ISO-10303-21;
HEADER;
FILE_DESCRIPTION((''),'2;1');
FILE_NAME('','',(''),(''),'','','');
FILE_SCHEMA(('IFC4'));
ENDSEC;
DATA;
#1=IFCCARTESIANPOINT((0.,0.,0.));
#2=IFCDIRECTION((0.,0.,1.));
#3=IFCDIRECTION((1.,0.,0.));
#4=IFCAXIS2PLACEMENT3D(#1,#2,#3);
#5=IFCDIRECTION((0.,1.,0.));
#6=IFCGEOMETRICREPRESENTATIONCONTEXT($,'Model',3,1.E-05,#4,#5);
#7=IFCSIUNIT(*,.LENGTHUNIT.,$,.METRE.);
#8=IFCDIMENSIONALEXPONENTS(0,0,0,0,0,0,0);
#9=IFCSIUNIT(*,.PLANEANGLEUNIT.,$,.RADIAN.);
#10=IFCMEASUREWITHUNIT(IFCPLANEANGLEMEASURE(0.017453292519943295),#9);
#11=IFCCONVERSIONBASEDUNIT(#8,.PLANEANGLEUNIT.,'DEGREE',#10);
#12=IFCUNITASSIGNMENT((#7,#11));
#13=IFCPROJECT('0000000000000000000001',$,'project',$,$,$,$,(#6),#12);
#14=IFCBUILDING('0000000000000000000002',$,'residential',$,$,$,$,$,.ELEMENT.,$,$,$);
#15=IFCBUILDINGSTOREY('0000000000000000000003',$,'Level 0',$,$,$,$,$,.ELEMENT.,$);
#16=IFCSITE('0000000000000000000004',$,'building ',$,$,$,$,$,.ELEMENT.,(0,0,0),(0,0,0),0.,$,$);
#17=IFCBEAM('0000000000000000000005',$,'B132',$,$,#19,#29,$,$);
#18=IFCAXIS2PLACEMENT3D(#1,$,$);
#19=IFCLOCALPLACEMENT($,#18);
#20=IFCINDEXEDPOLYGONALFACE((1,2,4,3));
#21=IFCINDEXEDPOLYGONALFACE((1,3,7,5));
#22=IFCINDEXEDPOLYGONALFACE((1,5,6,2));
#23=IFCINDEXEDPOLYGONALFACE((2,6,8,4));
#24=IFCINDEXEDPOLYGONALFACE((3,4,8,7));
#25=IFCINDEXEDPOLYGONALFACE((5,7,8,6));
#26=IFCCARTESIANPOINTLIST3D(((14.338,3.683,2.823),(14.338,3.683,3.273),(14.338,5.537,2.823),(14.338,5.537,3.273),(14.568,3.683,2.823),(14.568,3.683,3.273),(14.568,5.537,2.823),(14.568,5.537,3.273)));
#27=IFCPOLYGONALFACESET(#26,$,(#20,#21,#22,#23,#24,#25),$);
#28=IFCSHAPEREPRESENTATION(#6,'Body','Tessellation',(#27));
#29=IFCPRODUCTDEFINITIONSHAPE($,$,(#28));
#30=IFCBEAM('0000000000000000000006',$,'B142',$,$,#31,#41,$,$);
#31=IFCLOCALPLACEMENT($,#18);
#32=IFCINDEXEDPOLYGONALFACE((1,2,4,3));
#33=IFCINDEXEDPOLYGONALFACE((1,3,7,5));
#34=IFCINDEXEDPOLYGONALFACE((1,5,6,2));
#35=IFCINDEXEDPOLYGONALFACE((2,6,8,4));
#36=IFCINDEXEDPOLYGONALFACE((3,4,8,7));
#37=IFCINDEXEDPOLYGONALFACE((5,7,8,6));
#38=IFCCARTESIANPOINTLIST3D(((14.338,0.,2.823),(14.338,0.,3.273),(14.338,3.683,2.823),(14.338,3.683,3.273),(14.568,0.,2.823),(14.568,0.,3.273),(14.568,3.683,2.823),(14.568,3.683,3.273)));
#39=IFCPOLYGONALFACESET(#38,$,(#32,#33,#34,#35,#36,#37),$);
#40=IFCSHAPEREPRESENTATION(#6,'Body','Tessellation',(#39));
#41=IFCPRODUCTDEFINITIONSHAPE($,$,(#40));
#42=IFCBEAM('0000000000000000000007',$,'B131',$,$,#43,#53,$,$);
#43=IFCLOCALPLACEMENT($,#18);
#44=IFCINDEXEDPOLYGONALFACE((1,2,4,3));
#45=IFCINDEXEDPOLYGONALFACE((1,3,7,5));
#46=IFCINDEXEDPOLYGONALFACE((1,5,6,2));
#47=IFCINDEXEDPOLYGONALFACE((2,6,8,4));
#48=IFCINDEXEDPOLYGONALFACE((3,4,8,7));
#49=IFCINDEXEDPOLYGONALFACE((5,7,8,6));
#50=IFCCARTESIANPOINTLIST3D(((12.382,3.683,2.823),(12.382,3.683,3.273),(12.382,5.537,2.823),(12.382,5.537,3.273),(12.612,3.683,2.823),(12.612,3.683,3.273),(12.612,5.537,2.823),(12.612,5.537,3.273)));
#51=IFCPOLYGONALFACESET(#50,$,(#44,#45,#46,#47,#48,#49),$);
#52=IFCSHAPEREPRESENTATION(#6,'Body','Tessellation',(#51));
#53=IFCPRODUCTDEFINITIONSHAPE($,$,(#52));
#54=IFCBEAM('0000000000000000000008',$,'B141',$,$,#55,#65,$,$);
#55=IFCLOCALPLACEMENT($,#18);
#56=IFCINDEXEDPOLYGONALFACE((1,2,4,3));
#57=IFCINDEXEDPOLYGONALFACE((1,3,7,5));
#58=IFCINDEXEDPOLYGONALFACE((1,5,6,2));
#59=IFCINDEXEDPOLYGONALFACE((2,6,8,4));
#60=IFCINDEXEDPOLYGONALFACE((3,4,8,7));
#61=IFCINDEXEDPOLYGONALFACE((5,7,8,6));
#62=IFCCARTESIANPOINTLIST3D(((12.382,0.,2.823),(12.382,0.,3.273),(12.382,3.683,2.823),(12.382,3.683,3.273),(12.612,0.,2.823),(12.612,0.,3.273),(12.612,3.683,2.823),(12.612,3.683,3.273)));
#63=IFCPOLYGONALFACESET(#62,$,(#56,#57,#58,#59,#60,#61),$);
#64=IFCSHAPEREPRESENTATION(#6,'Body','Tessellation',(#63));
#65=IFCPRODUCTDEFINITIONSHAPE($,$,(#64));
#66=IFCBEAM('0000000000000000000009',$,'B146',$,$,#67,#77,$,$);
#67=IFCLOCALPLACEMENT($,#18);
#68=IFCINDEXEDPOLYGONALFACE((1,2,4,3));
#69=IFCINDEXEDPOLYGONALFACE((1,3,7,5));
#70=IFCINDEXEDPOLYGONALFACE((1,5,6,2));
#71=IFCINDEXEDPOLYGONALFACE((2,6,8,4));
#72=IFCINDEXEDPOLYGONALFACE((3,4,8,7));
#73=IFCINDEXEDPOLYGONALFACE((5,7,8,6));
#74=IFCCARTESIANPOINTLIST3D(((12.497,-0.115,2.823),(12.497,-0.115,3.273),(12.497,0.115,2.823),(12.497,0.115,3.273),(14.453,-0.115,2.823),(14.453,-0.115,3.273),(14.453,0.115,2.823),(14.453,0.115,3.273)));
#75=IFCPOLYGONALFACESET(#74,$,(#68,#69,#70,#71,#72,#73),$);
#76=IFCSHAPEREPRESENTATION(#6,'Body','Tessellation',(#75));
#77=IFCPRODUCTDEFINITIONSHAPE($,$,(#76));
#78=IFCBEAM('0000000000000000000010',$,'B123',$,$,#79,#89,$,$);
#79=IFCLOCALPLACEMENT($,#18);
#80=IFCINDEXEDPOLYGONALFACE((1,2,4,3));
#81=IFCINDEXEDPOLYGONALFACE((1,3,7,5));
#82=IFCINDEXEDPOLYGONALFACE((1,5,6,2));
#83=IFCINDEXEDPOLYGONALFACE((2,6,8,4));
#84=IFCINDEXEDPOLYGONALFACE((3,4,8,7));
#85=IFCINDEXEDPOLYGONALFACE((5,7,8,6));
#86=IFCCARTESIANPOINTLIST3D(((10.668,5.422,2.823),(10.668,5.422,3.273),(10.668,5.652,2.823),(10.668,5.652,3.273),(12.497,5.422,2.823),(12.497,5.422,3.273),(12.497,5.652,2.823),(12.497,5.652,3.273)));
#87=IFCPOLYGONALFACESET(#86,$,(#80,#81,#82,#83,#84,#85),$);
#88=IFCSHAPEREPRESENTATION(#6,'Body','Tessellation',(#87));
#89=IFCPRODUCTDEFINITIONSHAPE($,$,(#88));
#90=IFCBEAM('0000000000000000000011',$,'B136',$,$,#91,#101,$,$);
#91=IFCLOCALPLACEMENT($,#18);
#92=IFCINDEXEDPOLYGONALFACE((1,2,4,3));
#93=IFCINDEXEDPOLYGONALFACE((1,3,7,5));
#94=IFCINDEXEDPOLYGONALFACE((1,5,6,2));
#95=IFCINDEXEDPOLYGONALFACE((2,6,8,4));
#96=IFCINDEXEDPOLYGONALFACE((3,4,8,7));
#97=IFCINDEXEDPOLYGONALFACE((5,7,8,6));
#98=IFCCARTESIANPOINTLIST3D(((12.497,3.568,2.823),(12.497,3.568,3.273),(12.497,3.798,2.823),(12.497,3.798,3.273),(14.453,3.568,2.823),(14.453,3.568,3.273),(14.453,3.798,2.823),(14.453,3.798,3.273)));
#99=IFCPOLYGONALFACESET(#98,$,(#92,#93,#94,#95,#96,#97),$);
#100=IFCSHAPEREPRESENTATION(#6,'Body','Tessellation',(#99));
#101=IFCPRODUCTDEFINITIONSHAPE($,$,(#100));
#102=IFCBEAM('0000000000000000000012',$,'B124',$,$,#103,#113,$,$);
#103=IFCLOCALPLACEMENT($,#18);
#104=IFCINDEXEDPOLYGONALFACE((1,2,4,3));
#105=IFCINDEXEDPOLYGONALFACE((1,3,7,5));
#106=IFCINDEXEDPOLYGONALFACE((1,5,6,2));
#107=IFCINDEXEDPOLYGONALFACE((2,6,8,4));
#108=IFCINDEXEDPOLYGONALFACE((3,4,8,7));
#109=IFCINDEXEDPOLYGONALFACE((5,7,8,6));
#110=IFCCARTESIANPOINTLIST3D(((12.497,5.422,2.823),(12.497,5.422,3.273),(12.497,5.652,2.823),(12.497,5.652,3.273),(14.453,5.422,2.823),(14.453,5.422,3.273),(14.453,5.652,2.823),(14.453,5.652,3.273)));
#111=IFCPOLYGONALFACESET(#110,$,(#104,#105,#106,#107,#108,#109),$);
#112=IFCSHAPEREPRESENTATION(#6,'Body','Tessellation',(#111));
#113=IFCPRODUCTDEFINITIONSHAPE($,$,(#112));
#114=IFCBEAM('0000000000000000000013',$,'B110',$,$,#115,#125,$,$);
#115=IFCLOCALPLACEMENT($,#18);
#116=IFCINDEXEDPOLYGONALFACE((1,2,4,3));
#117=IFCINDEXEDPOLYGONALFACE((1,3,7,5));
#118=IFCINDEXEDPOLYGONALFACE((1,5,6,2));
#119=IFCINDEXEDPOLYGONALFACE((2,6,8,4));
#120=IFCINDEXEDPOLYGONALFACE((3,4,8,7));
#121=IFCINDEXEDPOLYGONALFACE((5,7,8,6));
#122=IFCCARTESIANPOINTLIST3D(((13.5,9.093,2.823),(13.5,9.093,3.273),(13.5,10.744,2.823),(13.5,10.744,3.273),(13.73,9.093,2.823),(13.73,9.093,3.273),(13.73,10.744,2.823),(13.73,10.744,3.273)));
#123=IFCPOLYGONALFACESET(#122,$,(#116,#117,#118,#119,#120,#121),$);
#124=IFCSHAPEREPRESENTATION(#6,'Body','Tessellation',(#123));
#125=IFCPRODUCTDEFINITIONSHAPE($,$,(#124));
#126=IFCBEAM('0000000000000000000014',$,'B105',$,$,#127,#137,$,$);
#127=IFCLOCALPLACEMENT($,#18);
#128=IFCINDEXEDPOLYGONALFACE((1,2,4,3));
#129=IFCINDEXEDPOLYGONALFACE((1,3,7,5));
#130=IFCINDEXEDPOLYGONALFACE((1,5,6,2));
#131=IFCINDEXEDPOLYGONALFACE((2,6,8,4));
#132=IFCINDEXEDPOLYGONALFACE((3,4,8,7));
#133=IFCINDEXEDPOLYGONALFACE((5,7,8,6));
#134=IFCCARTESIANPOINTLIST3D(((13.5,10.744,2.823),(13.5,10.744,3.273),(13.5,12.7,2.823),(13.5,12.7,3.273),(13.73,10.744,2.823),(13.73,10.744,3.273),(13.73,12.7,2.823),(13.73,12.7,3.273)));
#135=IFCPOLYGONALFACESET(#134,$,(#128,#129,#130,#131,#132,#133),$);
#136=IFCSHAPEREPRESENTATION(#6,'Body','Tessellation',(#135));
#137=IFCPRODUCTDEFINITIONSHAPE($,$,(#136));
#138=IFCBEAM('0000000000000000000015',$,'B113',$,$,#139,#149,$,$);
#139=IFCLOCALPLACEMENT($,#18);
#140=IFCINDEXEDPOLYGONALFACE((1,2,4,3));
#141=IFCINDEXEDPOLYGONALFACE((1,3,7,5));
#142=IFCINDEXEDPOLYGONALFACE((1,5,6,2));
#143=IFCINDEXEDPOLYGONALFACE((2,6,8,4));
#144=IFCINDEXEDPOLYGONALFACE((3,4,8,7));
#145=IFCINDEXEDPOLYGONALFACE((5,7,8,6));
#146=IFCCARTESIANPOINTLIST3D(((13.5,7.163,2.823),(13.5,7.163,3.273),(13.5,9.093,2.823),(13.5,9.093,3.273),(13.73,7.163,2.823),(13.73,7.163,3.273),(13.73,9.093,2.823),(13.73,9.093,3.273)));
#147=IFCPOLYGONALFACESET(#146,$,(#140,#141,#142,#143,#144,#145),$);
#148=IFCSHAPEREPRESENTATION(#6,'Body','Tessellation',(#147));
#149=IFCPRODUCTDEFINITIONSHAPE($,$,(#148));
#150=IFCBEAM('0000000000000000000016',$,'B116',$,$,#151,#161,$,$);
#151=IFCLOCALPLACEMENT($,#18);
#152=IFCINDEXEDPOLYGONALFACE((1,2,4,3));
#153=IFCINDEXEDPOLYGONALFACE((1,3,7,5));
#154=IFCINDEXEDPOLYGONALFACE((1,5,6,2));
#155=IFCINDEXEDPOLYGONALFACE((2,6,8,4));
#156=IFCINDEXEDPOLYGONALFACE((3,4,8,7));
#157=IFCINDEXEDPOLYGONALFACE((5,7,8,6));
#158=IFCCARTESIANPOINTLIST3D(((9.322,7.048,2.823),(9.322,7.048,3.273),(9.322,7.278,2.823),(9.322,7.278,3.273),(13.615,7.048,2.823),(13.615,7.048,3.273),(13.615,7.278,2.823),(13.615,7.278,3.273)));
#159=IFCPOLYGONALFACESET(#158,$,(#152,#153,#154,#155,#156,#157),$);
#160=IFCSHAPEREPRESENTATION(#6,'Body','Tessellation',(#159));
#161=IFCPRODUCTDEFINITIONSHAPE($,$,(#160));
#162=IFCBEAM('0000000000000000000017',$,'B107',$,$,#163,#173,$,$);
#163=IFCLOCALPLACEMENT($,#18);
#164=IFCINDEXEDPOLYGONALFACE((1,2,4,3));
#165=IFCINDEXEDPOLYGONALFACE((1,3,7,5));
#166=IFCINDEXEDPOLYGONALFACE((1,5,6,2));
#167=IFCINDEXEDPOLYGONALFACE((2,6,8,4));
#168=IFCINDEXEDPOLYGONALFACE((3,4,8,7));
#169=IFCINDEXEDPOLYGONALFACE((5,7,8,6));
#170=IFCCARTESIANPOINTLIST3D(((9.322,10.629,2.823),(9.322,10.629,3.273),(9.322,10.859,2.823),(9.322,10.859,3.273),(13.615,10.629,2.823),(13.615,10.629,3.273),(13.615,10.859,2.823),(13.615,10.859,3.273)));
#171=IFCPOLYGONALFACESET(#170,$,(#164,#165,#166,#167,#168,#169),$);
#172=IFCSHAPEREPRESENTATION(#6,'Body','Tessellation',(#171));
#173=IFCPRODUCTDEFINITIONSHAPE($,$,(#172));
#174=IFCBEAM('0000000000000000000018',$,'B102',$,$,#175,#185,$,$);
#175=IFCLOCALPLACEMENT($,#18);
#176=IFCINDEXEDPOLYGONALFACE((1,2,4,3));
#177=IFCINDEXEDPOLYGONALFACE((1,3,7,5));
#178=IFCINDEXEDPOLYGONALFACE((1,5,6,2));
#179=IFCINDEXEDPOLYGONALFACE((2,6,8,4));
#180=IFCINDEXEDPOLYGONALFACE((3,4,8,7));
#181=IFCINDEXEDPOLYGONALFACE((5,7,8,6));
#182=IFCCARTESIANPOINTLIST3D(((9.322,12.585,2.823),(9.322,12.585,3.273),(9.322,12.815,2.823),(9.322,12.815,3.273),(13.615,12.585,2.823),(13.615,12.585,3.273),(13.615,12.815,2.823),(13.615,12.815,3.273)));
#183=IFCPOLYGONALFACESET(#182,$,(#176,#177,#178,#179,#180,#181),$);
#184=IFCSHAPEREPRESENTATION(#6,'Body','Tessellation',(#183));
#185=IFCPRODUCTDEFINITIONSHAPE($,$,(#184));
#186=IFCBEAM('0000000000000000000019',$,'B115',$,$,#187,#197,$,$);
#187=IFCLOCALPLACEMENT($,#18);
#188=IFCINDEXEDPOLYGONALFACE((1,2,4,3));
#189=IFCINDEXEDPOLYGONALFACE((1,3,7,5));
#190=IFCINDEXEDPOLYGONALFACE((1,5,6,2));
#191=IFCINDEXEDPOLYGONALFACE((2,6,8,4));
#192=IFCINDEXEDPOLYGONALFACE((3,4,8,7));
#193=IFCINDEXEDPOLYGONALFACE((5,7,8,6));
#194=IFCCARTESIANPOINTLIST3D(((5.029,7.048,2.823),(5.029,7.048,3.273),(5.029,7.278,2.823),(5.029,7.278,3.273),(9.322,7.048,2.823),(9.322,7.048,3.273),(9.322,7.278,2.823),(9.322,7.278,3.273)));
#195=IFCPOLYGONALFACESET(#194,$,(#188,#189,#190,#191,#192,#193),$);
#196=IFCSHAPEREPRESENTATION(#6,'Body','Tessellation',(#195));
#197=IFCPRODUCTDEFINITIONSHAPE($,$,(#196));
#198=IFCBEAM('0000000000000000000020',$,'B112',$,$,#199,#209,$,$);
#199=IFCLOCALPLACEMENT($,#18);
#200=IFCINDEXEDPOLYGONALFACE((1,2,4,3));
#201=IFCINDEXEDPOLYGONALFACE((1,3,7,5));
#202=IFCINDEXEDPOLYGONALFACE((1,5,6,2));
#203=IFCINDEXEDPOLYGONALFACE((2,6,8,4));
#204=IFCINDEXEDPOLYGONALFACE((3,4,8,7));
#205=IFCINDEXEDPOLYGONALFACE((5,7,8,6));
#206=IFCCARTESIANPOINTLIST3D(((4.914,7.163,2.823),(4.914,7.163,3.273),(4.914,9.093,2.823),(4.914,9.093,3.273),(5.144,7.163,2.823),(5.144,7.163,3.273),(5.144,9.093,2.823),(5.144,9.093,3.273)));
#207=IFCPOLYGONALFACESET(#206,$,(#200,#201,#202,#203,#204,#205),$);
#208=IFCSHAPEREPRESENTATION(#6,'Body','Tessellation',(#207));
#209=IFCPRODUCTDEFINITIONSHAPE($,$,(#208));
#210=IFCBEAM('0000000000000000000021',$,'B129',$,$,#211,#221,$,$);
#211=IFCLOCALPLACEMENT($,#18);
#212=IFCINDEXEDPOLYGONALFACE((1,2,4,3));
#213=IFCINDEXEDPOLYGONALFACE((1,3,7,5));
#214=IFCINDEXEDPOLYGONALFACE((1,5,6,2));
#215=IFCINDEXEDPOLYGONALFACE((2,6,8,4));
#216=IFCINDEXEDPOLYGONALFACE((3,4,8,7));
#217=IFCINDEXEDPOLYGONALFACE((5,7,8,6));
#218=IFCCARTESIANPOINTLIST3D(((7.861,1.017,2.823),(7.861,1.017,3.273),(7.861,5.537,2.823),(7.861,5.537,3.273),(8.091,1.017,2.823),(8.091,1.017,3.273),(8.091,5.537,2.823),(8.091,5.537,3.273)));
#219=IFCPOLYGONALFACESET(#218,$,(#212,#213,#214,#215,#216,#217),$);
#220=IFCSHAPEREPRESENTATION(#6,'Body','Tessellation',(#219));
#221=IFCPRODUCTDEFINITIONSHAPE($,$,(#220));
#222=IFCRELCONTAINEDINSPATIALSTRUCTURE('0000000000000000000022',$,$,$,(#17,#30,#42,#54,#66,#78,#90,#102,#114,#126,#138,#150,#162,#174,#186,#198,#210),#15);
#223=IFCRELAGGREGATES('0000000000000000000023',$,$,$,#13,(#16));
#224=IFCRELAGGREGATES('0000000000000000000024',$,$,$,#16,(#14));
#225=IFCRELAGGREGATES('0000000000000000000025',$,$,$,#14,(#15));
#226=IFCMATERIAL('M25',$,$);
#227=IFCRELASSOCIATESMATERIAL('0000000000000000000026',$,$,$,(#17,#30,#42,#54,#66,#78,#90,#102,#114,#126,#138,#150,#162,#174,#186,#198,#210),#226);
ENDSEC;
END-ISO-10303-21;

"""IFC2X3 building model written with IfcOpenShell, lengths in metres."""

from ifc_helpers import new_model, entity, si_unit, converted_unit, direction, frame, frame_2d, origin_with_axes, place, context, project, spatial, rectangle, extrude, material, element, save


model = new_model("IFC2X3")

# Units and contexts
model_context = context("Model", 3, precision=1e-05, world=origin_with_axes(), true_north=direction((0.0, 1.0, 0.0)))
ifc_project = project(units=[si_unit("LENGTHUNIT", "METRE"), converted_unit("PLANEANGLEUNIT", "DEGREE", entity("IfcPlaneAngleMeasure", 0.017453292519943295), si_unit("PLANEANGLEUNIT", "RADIAN"), dimensions=[0, 0, 0, 0, 0, 0, 0])], contexts=[model_context])

# Site, building, storey
site = spatial("IfcSite", under=ifc_project, Name="building ", CompositionType="ELEMENT", RefLatitude=(0, 0, 0), RefLongitude=(0, 0, 0), RefElevation=0.0)
building = spatial("IfcBuilding", under=site, Name="residential", CompositionType="ELEMENT")
storey = spatial("IfcBuildingStorey", under=building, Name="Level 0", CompositionType="ELEMENT")

# Beams
ifc_material = material(Name="M25")
placement = place(None, origin_with_axes())
element("IfcBeam", 1, at=placement, inside=storey, material=ifc_material, Name="B132", context=model_context, shape_type="SweptSolid", body=[
    extrude(rectangle(XDim=0.23, YDim=0.45, at=frame_2d((0.0, 0.0), x_axis=(0.0, 1.0, 0.0))), frame((14.453, 3.683, 3.048), z_axis=(0.0, 1.0, 0.0), x_axis=(0.0, 0.0, -1.0)), (0.0, 0.0, 1.0), 1.854),
])
element("IfcBeam", 2, at=placement, inside=storey, material=ifc_material, Name="B142", context=model_context, shape_type="SweptSolid", body=[
    extrude(rectangle(XDim=0.23, YDim=0.45, at=frame_2d((0.0, 0.0), x_axis=(0.0, 1.0, 0.0))), frame((14.453, 0.0, 3.048), z_axis=(0.0, 1.0, 0.0), x_axis=(0.0, 0.0, -1.0)), (0.0, 0.0, 1.0), 3.683),
])
element("IfcBeam", 3, at=placement, inside=storey, material=ifc_material, Name="B131", context=model_context, shape_type="SweptSolid", body=[
    extrude(rectangle(XDim=0.23, YDim=0.45, at=frame_2d((0.0, 0.0), x_axis=(0.0, 1.0, 0.0))), frame((12.497, 3.683, 3.048), z_axis=(0.0, 1.0, 0.0), x_axis=(0.0, 0.0, -1.0)), (0.0, 0.0, 1.0), 1.854),
])
element("IfcBeam", 4, at=placement, inside=storey, material=ifc_material, Name="B141", context=model_context, shape_type="SweptSolid", body=[
    extrude(rectangle(XDim=0.23, YDim=0.45, at=frame_2d((0.0, 0.0), x_axis=(0.0, 1.0, 0.0))), frame((12.497, 0.0, 3.048), z_axis=(0.0, 1.0, 0.0), x_axis=(0.0, 0.0, -1.0)), (0.0, 0.0, 1.0), 3.683),
])
element("IfcBeam", 5, at=placement, inside=storey, material=ifc_material, Name="B146", context=model_context, shape_type="SweptSolid", body=[
    extrude(rectangle(XDim=0.23, YDim=0.45, at=frame_2d((0.0, 0.0), x_axis=(0.0, 1.0, 0.0))), frame((12.497, 0.0, 3.048), z_axis=(1.0, 0.0, 0.0), x_axis=(0.0, 0.0, -1.0)), (0.0, 0.0, 1.0), 1.956),
])
element("IfcBeam", 6, at=placement, inside=storey, material=ifc_material, Name="B123", context=model_context, shape_type="SweptSolid", body=[
    extrude(rectangle(XDim=0.23, YDim=0.45, at=frame_2d((0.0, 0.0), x_axis=(0.0, 1.0, 0.0))), frame((10.668, 5.537, 3.048), z_axis=(1.0, 0.0, 0.0), x_axis=(0.0, 0.0, -1.0)), (0.0, 0.0, 1.0), 1.829),
])
element("IfcBeam", 7, at=placement, inside=storey, material=ifc_material, Name="B136", context=model_context, shape_type="SweptSolid", body=[
    extrude(rectangle(XDim=0.23, YDim=0.45, at=frame_2d((0.0, 0.0), x_axis=(0.0, 1.0, 0.0))), frame((12.497, 3.683, 3.048), z_axis=(1.0, 0.0, 0.0), x_axis=(0.0, 0.0, -1.0)), (0.0, 0.0, 1.0), 1.956),
])
element("IfcBeam", 8, at=placement, inside=storey, material=ifc_material, Name="B124", context=model_context, shape_type="SweptSolid", body=[
    extrude(rectangle(XDim=0.23, YDim=0.45, at=frame_2d((0.0, 0.0), x_axis=(0.0, 1.0, 0.0))), frame((12.497, 5.537, 3.048), z_axis=(1.0, 0.0, 0.0), x_axis=(0.0, 0.0, -1.0)), (0.0, 0.0, 1.0), 1.956),
])
element("IfcBeam", 9, at=placement, inside=storey, material=ifc_material, Name="B110", context=model_context, shape_type="SweptSolid", body=[
    extrude(rectangle(XDim=0.23, YDim=0.45, at=frame_2d((0.0, 0.0), x_axis=(0.0, 1.0, 0.0))), frame((13.615, 9.093, 3.048), z_axis=(0.0, 1.0, 0.0), x_axis=(0.0, 0.0, -1.0)), (0.0, 0.0, 1.0), 1.651),
])
element("IfcBeam", 10, at=placement, inside=storey, material=ifc_material, Name="B105", context=model_context, shape_type="SweptSolid", body=[
    extrude(rectangle(XDim=0.23, YDim=0.45, at=frame_2d((0.0, 0.0), x_axis=(0.0, 1.0, 0.0))), frame((13.615, 10.744, 3.048), z_axis=(0.0, 1.0, 0.0), x_axis=(0.0, 0.0, -1.0)), (0.0, 0.0, 1.0), 1.956),
])
element("IfcBeam", 11, at=placement, inside=storey, material=ifc_material, Name="B113", context=model_context, shape_type="SweptSolid", body=[
    extrude(rectangle(XDim=0.23, YDim=0.45, at=frame_2d((0.0, 0.0), x_axis=(0.0, 1.0, 0.0))), frame((13.615, 7.163, 3.048), z_axis=(0.0, 1.0, 0.0), x_axis=(0.0, 0.0, -1.0)), (0.0, 0.0, 1.0), 1.93),
])
element("IfcBeam", 12, at=placement, inside=storey, material=ifc_material, Name="B116", context=model_context, shape_type="SweptSolid", body=[
    extrude(rectangle(XDim=0.23, YDim=0.45, at=frame_2d((0.0, 0.0), x_axis=(0.0, 1.0, 0.0))), frame((9.322, 7.163, 3.048), z_axis=(1.0, 0.0, 0.0), x_axis=(0.0, 0.0, -1.0)), (0.0, 0.0, 1.0), 4.293),
])
element("IfcBeam", 13, at=placement, inside=storey, material=ifc_material, Name="B107", context=model_context, shape_type="SweptSolid", body=[
    extrude(rectangle(XDim=0.23, YDim=0.45, at=frame_2d((0.0, 0.0), x_axis=(0.0, 1.0, 0.0))), frame((9.322, 10.744, 3.048), z_axis=(1.0, 0.0, 0.0), x_axis=(0.0, 0.0, -1.0)), (0.0, 0.0, 1.0), 4.293),
])
element("IfcBeam", 14, at=placement, inside=storey, material=ifc_material, Name="B102", context=model_context, shape_type="SweptSolid", body=[
    extrude(rectangle(XDim=0.23, YDim=0.45, at=frame_2d((0.0, 0.0), x_axis=(0.0, 1.0, 0.0))), frame((9.322, 12.7, 3.048), z_axis=(1.0, 0.0, 0.0), x_axis=(0.0, 0.0, -1.0)), (0.0, 0.0, 1.0), 4.293),
])
element("IfcBeam", 15, at=placement, inside=storey, material=ifc_material, Name="B115", context=model_context, shape_type="SweptSolid", body=[
    extrude(rectangle(XDim=0.23, YDim=0.45, at=frame_2d((0.0, 0.0), x_axis=(0.0, 1.0, 0.0))), frame((5.029, 7.163, 3.048), z_axis=(1.0, 0.0, 0.0), x_axis=(0.0, 0.0, -1.0)), (0.0, 0.0, 1.0), 4.293),
])
element("IfcBeam", 16, at=placement, inside=storey, material=ifc_material, Name="B112", context=model_context, shape_type="SweptSolid", body=[
    extrude(rectangle(XDim=0.23, YDim=0.45, at=frame_2d((0.0, 0.0), x_axis=(0.0, 1.0, 0.0))), frame((5.029, 9.093, 3.048), z_axis=(0.0, -1.0, 0.0), x_axis=(0.0, 0.0, -1.0)), (0.0, 0.0, 1.0), 1.93),
])
element("IfcBeam", 17, at=placement, inside=storey, material=ifc_material, Name="B129", context=model_context, shape_type="SweptSolid", body=[
    extrude(rectangle(XDim=0.23, YDim=0.45, at=frame_2d((0.0, 0.0), x_axis=(0.0, 1.0, 0.0))), frame((7.976, 1.017, 3.048), z_axis=(0.0, 1.0, 0.0), x_axis=(0.0, 0.0, -1.0)), (0.0, 0.0, 1.0), 4.52),
])

save(model, "model.ifc")
